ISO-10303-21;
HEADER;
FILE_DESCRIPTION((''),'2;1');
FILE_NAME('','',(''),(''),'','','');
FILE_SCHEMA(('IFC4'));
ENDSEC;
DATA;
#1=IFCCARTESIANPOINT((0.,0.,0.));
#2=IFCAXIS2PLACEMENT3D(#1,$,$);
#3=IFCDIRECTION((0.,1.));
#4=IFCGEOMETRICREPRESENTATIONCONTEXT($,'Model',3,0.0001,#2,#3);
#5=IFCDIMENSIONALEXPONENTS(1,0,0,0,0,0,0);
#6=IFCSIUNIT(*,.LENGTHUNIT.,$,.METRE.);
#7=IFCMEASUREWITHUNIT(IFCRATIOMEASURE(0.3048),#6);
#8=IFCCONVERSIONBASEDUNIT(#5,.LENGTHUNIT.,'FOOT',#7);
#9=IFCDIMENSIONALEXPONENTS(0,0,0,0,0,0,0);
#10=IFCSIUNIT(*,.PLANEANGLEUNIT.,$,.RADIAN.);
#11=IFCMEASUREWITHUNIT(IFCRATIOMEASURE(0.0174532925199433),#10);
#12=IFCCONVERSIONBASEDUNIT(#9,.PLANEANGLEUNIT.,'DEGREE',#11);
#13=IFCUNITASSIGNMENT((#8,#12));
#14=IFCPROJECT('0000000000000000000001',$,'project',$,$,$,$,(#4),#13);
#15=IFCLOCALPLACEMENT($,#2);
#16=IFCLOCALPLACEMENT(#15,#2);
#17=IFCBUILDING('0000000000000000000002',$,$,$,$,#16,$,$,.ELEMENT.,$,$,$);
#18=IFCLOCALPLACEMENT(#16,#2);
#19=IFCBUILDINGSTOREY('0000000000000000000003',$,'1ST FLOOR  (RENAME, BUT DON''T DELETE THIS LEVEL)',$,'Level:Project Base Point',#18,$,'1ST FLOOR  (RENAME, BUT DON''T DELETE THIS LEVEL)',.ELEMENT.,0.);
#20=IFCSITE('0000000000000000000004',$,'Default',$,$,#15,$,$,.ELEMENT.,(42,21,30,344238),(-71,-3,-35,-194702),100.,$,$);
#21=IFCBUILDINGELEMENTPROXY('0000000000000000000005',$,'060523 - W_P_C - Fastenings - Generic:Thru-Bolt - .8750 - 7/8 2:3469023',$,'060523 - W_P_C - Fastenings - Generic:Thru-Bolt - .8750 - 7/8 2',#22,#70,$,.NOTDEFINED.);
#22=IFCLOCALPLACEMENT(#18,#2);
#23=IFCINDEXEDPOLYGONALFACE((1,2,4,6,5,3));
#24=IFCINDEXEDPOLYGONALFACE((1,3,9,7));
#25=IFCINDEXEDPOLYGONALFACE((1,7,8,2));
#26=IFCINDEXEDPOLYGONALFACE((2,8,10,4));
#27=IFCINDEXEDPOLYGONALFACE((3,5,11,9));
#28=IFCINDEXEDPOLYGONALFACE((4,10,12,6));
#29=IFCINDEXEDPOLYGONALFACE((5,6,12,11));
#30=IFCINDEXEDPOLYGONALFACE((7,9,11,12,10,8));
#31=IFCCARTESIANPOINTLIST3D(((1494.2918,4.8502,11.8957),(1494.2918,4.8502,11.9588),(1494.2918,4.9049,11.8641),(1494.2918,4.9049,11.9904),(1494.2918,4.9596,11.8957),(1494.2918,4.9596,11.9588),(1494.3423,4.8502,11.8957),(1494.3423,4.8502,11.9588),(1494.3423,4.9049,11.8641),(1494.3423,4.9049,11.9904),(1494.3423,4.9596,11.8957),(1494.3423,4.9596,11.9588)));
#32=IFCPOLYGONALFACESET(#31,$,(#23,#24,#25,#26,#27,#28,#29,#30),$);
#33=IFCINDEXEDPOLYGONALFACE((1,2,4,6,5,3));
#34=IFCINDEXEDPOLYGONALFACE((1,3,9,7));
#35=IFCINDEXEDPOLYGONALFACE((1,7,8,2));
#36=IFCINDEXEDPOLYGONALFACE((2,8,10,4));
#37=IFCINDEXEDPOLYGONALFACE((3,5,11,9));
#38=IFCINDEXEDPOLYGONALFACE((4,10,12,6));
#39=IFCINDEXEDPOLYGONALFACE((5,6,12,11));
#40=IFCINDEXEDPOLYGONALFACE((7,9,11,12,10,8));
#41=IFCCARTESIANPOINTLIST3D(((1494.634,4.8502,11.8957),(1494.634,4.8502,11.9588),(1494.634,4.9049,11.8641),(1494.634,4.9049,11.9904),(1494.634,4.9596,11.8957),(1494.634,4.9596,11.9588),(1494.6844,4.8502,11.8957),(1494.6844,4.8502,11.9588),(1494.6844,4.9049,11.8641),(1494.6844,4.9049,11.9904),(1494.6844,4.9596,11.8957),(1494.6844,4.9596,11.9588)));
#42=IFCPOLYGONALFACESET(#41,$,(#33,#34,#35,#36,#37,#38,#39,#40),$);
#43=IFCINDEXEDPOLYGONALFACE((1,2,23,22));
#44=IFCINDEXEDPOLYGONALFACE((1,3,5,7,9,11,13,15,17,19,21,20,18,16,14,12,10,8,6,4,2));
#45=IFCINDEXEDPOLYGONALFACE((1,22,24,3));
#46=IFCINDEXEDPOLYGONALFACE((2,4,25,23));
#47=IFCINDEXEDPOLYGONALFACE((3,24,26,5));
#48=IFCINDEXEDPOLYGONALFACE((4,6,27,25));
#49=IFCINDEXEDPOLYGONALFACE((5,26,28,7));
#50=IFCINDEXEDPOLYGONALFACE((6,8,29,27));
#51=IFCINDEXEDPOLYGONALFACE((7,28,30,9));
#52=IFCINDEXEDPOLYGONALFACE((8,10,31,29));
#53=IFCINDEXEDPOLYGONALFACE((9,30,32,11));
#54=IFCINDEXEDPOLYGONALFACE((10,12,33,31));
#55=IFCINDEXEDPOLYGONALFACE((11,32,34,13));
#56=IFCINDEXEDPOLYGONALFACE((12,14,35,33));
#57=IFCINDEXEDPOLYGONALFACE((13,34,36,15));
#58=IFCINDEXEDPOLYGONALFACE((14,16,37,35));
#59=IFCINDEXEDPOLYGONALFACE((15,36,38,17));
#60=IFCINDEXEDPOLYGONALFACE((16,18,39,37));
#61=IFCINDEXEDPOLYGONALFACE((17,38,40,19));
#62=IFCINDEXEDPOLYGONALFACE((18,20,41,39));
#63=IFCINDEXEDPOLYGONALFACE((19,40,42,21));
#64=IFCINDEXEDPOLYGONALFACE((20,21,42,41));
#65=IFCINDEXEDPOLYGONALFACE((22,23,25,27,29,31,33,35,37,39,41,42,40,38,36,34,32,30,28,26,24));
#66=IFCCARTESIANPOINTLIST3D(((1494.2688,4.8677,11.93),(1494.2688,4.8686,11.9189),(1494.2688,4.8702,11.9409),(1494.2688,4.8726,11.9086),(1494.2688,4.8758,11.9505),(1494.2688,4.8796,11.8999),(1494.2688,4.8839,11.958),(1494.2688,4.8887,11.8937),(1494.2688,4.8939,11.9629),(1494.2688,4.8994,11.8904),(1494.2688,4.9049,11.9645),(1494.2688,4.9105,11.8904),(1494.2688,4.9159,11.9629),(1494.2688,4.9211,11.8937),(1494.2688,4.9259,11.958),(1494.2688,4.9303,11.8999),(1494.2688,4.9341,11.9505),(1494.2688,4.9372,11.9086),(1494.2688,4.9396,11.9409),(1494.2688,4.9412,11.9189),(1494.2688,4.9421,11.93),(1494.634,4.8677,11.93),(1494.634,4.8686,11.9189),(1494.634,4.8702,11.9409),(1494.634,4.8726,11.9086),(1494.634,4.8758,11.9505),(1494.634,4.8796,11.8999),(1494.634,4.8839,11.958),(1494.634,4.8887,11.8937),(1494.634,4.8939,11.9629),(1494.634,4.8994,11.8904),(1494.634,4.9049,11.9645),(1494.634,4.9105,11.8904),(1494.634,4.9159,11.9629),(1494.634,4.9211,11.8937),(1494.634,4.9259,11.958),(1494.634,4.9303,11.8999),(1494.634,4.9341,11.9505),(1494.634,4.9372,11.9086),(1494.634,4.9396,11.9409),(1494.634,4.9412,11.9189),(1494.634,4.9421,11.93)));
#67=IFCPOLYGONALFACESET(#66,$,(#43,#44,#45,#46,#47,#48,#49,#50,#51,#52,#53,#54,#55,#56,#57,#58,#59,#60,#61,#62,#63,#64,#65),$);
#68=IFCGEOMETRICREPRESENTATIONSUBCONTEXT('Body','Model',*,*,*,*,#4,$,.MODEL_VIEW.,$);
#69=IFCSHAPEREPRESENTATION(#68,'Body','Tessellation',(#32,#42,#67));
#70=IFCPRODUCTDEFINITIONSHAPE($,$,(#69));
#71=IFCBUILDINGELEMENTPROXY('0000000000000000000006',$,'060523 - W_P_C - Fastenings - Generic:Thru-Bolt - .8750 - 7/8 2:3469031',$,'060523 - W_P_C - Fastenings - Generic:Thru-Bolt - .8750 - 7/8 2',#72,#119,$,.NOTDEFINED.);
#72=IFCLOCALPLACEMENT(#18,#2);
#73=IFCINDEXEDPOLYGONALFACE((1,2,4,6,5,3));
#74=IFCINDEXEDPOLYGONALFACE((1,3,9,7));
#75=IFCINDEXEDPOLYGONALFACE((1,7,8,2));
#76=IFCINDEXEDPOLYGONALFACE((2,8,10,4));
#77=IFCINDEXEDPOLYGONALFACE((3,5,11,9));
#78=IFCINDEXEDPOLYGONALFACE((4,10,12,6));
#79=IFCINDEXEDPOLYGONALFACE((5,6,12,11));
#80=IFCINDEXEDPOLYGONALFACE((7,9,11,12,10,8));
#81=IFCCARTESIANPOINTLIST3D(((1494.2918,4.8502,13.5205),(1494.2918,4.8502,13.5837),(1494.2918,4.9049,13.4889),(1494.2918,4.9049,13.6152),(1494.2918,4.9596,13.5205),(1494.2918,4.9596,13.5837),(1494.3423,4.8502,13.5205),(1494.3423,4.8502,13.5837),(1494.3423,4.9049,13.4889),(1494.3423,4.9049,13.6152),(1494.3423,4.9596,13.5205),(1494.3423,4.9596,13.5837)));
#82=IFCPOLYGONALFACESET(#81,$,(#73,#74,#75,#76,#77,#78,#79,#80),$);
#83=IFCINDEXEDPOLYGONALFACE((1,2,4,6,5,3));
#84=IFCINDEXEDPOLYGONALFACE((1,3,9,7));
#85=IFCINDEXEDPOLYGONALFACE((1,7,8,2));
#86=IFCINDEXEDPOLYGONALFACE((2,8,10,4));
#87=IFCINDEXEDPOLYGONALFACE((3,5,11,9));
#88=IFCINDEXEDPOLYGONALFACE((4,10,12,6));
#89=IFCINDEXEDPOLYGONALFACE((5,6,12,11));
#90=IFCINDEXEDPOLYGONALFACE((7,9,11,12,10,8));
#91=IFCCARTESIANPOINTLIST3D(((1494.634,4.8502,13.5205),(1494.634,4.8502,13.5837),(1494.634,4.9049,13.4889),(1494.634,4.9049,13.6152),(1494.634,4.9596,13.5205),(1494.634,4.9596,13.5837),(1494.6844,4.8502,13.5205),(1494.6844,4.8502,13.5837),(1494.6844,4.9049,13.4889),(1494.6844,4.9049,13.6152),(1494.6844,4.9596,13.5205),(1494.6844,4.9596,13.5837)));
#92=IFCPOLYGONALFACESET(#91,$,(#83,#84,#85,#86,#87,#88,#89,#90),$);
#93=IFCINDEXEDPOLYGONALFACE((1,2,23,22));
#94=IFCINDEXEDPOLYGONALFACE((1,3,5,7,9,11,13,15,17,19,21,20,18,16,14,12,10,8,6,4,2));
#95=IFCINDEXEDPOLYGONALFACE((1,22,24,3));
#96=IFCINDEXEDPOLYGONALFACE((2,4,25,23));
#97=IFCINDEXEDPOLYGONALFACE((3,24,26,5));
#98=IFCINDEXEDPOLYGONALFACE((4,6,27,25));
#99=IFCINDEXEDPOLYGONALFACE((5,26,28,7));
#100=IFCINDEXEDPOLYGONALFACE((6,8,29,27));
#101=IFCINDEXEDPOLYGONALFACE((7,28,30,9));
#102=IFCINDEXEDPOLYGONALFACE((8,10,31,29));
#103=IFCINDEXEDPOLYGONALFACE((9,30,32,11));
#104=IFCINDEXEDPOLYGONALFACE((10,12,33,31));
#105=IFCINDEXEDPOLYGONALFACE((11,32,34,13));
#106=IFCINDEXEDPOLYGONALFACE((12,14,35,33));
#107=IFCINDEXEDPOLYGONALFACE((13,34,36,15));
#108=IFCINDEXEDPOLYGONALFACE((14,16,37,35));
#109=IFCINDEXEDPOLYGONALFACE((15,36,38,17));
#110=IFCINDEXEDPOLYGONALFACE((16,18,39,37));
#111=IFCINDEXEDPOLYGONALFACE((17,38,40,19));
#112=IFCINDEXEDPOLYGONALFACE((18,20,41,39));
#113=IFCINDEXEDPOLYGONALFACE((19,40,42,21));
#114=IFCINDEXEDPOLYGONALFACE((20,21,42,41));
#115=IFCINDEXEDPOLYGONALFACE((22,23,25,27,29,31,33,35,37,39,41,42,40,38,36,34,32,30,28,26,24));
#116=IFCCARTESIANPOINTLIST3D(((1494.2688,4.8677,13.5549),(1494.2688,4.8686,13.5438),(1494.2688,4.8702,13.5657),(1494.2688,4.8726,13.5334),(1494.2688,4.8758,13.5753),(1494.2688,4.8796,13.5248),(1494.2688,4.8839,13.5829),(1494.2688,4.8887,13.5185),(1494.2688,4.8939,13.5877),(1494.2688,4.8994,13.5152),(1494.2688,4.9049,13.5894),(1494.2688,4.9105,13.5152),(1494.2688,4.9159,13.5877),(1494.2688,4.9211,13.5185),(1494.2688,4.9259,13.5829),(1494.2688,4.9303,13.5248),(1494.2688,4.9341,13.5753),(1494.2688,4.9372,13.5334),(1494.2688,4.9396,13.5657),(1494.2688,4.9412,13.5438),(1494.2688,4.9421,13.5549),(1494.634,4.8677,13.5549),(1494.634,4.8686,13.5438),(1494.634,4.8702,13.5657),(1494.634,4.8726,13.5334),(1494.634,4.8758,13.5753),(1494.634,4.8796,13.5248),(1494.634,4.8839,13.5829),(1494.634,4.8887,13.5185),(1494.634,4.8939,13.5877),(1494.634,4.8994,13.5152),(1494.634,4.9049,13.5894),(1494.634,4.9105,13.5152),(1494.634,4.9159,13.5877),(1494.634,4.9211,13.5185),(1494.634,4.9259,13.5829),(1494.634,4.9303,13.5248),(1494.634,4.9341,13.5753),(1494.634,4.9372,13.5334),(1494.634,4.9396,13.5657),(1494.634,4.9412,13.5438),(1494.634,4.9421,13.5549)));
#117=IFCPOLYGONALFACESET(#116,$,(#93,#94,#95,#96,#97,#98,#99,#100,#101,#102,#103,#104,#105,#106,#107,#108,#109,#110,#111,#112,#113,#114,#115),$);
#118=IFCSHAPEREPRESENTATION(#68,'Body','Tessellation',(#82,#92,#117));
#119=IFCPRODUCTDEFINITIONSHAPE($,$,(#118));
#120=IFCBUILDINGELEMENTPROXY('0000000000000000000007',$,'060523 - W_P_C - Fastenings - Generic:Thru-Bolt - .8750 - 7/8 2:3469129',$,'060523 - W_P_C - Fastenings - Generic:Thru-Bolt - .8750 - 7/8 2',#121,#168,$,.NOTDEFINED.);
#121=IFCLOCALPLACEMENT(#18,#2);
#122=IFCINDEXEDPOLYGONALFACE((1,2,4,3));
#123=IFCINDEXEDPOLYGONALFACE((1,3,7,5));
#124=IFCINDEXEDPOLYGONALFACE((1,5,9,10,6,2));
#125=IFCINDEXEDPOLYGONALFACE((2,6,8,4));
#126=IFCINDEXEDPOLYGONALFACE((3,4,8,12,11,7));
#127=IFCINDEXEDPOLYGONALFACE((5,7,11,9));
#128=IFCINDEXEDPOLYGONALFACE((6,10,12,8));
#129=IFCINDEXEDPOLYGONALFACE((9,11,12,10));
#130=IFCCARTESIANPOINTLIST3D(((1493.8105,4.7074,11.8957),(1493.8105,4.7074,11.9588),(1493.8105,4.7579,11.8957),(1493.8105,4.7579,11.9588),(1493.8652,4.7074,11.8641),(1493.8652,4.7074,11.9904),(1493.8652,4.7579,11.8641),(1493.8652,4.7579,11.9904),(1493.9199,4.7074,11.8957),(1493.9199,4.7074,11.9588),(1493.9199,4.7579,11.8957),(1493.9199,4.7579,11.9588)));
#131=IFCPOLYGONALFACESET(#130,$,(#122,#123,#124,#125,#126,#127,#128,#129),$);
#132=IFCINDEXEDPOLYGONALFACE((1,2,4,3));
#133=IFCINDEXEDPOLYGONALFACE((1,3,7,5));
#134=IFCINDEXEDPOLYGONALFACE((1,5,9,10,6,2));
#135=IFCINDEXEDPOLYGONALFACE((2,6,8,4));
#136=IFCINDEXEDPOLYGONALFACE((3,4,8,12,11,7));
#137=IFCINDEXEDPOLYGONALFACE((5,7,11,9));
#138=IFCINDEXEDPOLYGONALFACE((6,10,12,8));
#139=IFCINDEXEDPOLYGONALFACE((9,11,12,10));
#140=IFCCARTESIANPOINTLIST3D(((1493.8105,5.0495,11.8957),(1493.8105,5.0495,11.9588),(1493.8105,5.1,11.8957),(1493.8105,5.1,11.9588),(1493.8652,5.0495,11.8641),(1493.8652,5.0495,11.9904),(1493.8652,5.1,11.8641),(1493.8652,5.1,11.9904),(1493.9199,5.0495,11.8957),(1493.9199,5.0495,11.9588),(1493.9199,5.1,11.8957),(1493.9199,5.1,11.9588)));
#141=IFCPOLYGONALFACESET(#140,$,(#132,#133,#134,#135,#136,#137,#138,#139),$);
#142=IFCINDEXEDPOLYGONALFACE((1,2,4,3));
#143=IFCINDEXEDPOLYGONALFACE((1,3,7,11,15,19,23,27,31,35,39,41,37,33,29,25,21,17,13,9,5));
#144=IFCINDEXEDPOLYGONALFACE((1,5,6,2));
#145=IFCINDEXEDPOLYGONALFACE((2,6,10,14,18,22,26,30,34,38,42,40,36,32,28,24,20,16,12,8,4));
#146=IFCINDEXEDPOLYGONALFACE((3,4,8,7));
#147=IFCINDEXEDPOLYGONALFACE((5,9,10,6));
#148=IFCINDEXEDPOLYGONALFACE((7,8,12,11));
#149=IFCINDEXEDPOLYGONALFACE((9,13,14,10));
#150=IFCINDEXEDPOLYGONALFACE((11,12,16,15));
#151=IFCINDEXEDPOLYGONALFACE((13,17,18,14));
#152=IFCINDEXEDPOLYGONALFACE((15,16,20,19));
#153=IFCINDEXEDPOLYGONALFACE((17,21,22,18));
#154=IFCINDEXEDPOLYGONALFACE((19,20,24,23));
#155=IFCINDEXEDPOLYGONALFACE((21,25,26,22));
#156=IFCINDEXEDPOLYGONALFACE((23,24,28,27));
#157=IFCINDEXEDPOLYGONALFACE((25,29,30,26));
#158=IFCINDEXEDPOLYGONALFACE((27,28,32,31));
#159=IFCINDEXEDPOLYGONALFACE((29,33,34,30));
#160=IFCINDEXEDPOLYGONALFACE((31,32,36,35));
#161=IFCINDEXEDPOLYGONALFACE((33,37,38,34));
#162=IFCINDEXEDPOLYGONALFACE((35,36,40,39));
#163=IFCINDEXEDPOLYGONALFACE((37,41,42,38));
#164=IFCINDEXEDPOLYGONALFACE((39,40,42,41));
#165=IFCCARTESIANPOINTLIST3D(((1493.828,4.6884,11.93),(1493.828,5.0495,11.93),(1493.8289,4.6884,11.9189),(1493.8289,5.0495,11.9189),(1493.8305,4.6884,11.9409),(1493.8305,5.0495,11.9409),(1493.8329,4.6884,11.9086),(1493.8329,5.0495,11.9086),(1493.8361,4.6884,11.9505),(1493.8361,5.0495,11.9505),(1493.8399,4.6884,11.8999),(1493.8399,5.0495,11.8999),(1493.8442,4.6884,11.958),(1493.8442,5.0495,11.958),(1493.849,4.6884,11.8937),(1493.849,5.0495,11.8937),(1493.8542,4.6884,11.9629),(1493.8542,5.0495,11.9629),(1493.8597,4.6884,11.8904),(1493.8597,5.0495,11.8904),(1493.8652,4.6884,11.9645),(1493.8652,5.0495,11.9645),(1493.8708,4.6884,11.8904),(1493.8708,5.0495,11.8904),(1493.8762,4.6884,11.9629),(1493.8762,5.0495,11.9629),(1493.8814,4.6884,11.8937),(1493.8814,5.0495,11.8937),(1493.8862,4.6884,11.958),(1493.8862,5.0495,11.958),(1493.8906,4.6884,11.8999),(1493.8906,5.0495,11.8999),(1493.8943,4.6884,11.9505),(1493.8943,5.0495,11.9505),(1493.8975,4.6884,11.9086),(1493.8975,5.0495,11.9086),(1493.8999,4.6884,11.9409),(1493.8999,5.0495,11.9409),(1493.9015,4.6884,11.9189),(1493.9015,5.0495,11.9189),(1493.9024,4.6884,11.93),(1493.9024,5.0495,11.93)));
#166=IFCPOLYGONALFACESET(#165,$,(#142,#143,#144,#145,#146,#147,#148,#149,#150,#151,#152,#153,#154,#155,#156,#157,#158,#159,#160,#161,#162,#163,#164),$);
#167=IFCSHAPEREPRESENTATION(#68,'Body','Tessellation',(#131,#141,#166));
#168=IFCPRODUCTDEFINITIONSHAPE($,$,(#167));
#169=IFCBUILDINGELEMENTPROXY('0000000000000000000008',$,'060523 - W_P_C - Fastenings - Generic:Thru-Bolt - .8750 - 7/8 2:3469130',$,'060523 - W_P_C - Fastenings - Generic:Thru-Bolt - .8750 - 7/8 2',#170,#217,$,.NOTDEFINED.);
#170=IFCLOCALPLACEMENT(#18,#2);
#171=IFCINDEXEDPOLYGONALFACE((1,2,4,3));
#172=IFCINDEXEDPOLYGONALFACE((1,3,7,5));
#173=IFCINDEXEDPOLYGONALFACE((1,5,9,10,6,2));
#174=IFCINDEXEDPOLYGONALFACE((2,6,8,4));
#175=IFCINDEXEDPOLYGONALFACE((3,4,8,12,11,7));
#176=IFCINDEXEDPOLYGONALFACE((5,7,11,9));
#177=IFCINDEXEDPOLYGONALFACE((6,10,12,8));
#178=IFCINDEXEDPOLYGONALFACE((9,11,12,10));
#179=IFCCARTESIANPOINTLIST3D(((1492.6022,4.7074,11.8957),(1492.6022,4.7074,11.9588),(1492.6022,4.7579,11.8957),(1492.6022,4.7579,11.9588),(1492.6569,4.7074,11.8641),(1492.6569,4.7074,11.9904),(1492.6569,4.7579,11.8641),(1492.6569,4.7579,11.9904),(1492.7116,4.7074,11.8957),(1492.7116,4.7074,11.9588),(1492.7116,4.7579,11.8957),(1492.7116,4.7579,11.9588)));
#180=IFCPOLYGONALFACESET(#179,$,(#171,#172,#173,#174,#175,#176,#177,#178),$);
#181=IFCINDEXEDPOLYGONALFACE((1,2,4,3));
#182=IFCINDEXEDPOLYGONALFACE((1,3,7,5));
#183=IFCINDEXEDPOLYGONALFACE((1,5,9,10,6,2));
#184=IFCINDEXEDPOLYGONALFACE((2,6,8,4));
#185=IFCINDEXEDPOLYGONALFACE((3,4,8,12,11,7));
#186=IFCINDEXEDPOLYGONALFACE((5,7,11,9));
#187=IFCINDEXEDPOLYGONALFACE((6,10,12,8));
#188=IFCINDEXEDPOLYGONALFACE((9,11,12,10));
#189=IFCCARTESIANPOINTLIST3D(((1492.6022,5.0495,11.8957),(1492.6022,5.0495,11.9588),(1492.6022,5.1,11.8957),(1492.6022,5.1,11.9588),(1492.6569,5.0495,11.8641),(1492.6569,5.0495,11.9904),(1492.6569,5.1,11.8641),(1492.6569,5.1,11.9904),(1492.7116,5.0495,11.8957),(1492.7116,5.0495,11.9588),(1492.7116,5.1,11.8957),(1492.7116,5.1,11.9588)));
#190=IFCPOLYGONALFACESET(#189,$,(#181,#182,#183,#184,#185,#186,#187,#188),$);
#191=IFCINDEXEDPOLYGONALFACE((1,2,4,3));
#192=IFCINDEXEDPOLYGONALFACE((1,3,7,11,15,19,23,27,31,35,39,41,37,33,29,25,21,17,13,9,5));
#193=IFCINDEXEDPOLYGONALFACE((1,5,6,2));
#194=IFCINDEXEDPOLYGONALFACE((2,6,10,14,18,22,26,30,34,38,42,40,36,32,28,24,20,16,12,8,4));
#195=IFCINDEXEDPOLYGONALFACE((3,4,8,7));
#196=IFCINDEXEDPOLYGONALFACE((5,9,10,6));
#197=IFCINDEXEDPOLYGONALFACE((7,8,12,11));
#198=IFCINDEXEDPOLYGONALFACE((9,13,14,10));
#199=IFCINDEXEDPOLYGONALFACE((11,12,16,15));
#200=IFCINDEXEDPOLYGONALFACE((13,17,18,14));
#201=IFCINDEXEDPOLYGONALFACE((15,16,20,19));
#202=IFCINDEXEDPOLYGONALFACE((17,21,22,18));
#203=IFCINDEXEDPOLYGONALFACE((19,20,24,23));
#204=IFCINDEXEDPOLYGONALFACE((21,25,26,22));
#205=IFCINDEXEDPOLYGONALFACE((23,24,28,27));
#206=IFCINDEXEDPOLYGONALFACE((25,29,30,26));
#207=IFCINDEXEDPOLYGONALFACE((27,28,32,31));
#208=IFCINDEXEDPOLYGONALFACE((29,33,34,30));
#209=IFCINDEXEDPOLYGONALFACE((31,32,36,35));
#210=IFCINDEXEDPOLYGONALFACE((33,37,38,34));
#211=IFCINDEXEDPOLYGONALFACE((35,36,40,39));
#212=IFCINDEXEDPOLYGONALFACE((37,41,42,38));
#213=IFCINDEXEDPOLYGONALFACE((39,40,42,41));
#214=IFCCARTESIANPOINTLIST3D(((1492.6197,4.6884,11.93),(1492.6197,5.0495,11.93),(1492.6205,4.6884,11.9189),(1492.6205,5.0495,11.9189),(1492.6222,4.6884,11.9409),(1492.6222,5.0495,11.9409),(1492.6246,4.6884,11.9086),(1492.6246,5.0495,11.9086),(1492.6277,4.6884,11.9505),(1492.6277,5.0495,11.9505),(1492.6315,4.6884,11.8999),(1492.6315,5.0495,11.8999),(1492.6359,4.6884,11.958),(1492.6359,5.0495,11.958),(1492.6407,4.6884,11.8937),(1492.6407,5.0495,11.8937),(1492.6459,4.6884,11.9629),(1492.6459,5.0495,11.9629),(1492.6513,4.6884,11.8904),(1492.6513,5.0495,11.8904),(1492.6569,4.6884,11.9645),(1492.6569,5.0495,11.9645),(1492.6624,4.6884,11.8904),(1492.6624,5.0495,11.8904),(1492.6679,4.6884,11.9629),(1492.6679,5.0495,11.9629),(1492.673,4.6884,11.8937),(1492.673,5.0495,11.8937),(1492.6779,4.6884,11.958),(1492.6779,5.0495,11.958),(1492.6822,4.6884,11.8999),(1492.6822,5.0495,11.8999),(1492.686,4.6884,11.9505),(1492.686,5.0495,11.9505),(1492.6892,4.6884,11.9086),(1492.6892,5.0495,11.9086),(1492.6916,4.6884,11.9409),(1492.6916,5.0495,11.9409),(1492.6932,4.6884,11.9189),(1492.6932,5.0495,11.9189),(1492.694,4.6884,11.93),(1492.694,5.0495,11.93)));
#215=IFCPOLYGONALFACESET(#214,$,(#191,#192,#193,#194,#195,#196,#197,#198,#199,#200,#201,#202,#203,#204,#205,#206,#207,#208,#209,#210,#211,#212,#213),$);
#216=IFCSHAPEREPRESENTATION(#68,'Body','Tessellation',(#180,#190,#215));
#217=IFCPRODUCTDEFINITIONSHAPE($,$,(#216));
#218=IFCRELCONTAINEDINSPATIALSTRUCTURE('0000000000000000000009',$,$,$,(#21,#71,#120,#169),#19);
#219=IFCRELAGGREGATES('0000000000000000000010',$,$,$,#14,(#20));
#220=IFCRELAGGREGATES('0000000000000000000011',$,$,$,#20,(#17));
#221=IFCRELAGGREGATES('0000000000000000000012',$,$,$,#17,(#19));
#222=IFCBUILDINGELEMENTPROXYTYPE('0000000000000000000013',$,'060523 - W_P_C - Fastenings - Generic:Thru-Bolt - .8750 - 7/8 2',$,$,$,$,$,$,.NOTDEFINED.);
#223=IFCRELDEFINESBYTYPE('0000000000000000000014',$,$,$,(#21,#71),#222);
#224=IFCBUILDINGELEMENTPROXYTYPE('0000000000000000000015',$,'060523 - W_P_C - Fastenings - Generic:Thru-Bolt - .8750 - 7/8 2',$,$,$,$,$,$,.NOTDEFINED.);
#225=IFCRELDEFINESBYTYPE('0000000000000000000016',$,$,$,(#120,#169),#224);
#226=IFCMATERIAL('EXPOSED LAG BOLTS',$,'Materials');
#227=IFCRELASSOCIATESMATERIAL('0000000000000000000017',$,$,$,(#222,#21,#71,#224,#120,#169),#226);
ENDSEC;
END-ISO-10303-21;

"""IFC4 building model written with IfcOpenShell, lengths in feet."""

from ifc_helpers import new_model, entity, si_unit, converted_unit, direction, frame, frame_2d, origin, place, context, subcontext, project, spatial, polyline, circle, outline, extrude, source, transform, mapped, material, type_object, type_shapes, element, save


model = new_model("IFC4")

# Units and contexts
model_context = context("Model", 3, precision=0.0001, world=origin(), true_north=direction((0.0, 1.0)))
body_context = subcontext(model_context, "Body", "Model", "MODEL_VIEW")
ifc_project = project(units=[converted_unit("LENGTHUNIT", "FOOT", entity("IfcRatioMeasure", 0.3048), si_unit("LENGTHUNIT", "METRE"), dimensions=[1, 0, 0, 0, 0, 0, 0]), converted_unit("PLANEANGLEUNIT", "DEGREE", entity("IfcRatioMeasure", 0.0174532925199433), si_unit("PLANEANGLEUNIT", "RADIAN"), dimensions=[0, 0, 0, 0, 0, 0, 0])], contexts=[model_context])

# Site, building, storey
site_placement = place(None, origin())
site = spatial("IfcSite", under=ifc_project, at=site_placement, Name="Default", CompositionType="ELEMENT", RefLatitude=(42, 21, 30, 344238), RefLongitude=(-71, -3, -35, -194702), RefElevation=100.0)
building_placement = place(site_placement, origin())
building = spatial("IfcBuilding", under=site, at=building_placement, CompositionType="ELEMENT")
storey_placement = place(building_placement, origin())
storey = spatial("IfcBuildingStorey", under=building, at=storey_placement, Name="1ST FLOOR  (RENAME, BUT DON'T DELETE THIS LEVEL)", ObjectType="Level:Project Base Point", LongName="1ST FLOOR  (RENAME, BUT DON'T DELETE THIS LEVEL)", CompositionType="ELEMENT", Elevation=0.0)

# Building element proxies
ifc_material_1 = material(Name="EXPOSED LAG BOLTS", Category="Materials")
building_element_proxy_type_1 = type_object("IfcBuildingElementProxyType", Name="060523 - W_P_C - Fastenings - Generic:Thru-Bolt - .8750 - 7/8 2", PredefinedType="NOTDEFINED", material=ifc_material_1)
shared_shape_1 = source(origin(), body_context, "Body", "SweptSolid", [
    extrude(outline(polyline([(-0.0316, -0.0547), (0.0316, -0.0547), (0.0631, 0.0), (0.0316, 0.0547), (-0.0316, 0.0547), (-0.0631, 0.0), (-0.0316, -0.0547)])), frame((0.0, 0.0, -0.3421), z_axis=(0.0, 0.0, 1.0), x_axis=(0.866025, -0.5, 0.0)), (0.0, 0.0, 1.0), 0.0505),
    extrude(outline(polyline([(-0.0316, -0.0547), (0.0316, -0.0547), (0.0631, 0.0), (0.0316, 0.0547), (-0.0316, 0.0547), (-0.0631, 0.0), (-0.0316, -0.0547)])), frame((0.0, 0.0, 0.0), z_axis=(0.0, 0.0, 1.0), x_axis=(0.0, -1.0, 0.0)), (0.0, 0.0, 1.0), 0.0505),
    extrude(circle(Radius=0.0373, at=frame_2d((0.0, 0.0), x_axis=(1.0, 0.0))), frame((0.0, 0.0, -0.3652), z_axis=(0.0, 0.0, 1.0), x_axis=(0.0, 1.0, 0.0)), (0.0, 0.0, 1.0), 0.3652),
])
type_shapes(building_element_proxy_type_1, [shared_shape_1])
for number, where, z_axis, x_axis, name in (
    (1, (1494.634, 4.9049, 11.9272), (1.0, 0.0, 0.0), (0.0, 1.0, 0.0), "060523 - W_P_C - Fastenings - Generic:Thru-Bolt - .8750 - 7/8 2:3469023"),
    (2, (1494.634, 4.9049, 13.5521), (1.0, 0.0, 0.0), (0.0, 1.0, 0.0), "060523 - W_P_C - Fastenings - Generic:Thru-Bolt - .8750 - 7/8 2:3469031"),
):
    element("IfcBuildingElementProxy", number, at=place(storey_placement, frame(where, z_axis=z_axis, x_axis=x_axis)), inside=storey, type_object=building_element_proxy_type_1, material=ifc_material_1, Name=name, ObjectType="060523 - W_P_C - Fastenings - Generic:Thru-Bolt - .8750 - 7/8 2", PredefinedType="NOTDEFINED", context=body_context, shape_type="MappedRepresentation", body=[
        mapped(shared_shape_1, transform((0.0, 0.0, 0.0), scale=1.0)),
    ])
building_element_proxy_type_2 = type_object("IfcBuildingElementProxyType", Name="060523 - W_P_C - Fastenings - Generic:Thru-Bolt - .8750 - 7/8 2", PredefinedType="NOTDEFINED", material=ifc_material_1)
shared_shape_2 = source(origin(), body_context, "Body", "SweptSolid", [
    extrude(outline(polyline([(-0.0316, -0.0547), (0.0316, -0.0547), (0.0631, 0.0), (0.0316, 0.0547), (-0.0316, 0.0547), (-0.0631, 0.0), (-0.0316, -0.0547)])), frame((0.0, 0.0, -0.3421), z_axis=(0.0, 0.0, 1.0), x_axis=(0.866025, -0.5, 0.0)), (0.0, 0.0, 1.0), 0.0505),
    extrude(outline(polyline([(-0.0316, -0.0547), (0.0316, -0.0547), (0.0631, 0.0), (0.0316, 0.0547), (-0.0316, 0.0547), (-0.0631, 0.0), (-0.0316, -0.0547)])), frame((0.0, 0.0, 0.0), z_axis=(0.0, 0.0, 1.0), x_axis=(0.0, -1.0, 0.0)), (0.0, 0.0, 1.0), 0.0505),
    extrude(circle(Radius=0.0373, at=frame_2d((0.0, 0.0), x_axis=(1.0, 0.0))), frame((0.0, 0.0, -0.3611), z_axis=(0.0, 0.0, 1.0), x_axis=(0.0, 1.0, 0.0)), (0.0, 0.0, 1.0), 0.3611),
])
type_shapes(building_element_proxy_type_2, [shared_shape_2])
for number, where, z_axis, x_axis, name in (
    (3, (1493.8652, 5.0495, 11.9272), (0.0, 1.0, 0.0), (-1.0, 0.0, 0.0), "060523 - W_P_C - Fastenings - Generic:Thru-Bolt - .8750 - 7/8 2:3469129"),
    (4, (1492.6569, 5.0495, 11.9272), (0.0, 1.0, 0.0), (-1.0, 0.0, 0.0), "060523 - W_P_C - Fastenings - Generic:Thru-Bolt - .8750 - 7/8 2:3469130"),
):
    element("IfcBuildingElementProxy", number, at=place(storey_placement, frame(where, z_axis=z_axis, x_axis=x_axis)), inside=storey, type_object=building_element_proxy_type_2, material=ifc_material_1, Name=name, ObjectType="060523 - W_P_C - Fastenings - Generic:Thru-Bolt - .8750 - 7/8 2", PredefinedType="NOTDEFINED", context=body_context, shape_type="MappedRepresentation", body=[
        mapped(shared_shape_2, transform((0.0, 0.0, 0.0), scale=1.0)),
    ])

save(model, "model.ifc")
